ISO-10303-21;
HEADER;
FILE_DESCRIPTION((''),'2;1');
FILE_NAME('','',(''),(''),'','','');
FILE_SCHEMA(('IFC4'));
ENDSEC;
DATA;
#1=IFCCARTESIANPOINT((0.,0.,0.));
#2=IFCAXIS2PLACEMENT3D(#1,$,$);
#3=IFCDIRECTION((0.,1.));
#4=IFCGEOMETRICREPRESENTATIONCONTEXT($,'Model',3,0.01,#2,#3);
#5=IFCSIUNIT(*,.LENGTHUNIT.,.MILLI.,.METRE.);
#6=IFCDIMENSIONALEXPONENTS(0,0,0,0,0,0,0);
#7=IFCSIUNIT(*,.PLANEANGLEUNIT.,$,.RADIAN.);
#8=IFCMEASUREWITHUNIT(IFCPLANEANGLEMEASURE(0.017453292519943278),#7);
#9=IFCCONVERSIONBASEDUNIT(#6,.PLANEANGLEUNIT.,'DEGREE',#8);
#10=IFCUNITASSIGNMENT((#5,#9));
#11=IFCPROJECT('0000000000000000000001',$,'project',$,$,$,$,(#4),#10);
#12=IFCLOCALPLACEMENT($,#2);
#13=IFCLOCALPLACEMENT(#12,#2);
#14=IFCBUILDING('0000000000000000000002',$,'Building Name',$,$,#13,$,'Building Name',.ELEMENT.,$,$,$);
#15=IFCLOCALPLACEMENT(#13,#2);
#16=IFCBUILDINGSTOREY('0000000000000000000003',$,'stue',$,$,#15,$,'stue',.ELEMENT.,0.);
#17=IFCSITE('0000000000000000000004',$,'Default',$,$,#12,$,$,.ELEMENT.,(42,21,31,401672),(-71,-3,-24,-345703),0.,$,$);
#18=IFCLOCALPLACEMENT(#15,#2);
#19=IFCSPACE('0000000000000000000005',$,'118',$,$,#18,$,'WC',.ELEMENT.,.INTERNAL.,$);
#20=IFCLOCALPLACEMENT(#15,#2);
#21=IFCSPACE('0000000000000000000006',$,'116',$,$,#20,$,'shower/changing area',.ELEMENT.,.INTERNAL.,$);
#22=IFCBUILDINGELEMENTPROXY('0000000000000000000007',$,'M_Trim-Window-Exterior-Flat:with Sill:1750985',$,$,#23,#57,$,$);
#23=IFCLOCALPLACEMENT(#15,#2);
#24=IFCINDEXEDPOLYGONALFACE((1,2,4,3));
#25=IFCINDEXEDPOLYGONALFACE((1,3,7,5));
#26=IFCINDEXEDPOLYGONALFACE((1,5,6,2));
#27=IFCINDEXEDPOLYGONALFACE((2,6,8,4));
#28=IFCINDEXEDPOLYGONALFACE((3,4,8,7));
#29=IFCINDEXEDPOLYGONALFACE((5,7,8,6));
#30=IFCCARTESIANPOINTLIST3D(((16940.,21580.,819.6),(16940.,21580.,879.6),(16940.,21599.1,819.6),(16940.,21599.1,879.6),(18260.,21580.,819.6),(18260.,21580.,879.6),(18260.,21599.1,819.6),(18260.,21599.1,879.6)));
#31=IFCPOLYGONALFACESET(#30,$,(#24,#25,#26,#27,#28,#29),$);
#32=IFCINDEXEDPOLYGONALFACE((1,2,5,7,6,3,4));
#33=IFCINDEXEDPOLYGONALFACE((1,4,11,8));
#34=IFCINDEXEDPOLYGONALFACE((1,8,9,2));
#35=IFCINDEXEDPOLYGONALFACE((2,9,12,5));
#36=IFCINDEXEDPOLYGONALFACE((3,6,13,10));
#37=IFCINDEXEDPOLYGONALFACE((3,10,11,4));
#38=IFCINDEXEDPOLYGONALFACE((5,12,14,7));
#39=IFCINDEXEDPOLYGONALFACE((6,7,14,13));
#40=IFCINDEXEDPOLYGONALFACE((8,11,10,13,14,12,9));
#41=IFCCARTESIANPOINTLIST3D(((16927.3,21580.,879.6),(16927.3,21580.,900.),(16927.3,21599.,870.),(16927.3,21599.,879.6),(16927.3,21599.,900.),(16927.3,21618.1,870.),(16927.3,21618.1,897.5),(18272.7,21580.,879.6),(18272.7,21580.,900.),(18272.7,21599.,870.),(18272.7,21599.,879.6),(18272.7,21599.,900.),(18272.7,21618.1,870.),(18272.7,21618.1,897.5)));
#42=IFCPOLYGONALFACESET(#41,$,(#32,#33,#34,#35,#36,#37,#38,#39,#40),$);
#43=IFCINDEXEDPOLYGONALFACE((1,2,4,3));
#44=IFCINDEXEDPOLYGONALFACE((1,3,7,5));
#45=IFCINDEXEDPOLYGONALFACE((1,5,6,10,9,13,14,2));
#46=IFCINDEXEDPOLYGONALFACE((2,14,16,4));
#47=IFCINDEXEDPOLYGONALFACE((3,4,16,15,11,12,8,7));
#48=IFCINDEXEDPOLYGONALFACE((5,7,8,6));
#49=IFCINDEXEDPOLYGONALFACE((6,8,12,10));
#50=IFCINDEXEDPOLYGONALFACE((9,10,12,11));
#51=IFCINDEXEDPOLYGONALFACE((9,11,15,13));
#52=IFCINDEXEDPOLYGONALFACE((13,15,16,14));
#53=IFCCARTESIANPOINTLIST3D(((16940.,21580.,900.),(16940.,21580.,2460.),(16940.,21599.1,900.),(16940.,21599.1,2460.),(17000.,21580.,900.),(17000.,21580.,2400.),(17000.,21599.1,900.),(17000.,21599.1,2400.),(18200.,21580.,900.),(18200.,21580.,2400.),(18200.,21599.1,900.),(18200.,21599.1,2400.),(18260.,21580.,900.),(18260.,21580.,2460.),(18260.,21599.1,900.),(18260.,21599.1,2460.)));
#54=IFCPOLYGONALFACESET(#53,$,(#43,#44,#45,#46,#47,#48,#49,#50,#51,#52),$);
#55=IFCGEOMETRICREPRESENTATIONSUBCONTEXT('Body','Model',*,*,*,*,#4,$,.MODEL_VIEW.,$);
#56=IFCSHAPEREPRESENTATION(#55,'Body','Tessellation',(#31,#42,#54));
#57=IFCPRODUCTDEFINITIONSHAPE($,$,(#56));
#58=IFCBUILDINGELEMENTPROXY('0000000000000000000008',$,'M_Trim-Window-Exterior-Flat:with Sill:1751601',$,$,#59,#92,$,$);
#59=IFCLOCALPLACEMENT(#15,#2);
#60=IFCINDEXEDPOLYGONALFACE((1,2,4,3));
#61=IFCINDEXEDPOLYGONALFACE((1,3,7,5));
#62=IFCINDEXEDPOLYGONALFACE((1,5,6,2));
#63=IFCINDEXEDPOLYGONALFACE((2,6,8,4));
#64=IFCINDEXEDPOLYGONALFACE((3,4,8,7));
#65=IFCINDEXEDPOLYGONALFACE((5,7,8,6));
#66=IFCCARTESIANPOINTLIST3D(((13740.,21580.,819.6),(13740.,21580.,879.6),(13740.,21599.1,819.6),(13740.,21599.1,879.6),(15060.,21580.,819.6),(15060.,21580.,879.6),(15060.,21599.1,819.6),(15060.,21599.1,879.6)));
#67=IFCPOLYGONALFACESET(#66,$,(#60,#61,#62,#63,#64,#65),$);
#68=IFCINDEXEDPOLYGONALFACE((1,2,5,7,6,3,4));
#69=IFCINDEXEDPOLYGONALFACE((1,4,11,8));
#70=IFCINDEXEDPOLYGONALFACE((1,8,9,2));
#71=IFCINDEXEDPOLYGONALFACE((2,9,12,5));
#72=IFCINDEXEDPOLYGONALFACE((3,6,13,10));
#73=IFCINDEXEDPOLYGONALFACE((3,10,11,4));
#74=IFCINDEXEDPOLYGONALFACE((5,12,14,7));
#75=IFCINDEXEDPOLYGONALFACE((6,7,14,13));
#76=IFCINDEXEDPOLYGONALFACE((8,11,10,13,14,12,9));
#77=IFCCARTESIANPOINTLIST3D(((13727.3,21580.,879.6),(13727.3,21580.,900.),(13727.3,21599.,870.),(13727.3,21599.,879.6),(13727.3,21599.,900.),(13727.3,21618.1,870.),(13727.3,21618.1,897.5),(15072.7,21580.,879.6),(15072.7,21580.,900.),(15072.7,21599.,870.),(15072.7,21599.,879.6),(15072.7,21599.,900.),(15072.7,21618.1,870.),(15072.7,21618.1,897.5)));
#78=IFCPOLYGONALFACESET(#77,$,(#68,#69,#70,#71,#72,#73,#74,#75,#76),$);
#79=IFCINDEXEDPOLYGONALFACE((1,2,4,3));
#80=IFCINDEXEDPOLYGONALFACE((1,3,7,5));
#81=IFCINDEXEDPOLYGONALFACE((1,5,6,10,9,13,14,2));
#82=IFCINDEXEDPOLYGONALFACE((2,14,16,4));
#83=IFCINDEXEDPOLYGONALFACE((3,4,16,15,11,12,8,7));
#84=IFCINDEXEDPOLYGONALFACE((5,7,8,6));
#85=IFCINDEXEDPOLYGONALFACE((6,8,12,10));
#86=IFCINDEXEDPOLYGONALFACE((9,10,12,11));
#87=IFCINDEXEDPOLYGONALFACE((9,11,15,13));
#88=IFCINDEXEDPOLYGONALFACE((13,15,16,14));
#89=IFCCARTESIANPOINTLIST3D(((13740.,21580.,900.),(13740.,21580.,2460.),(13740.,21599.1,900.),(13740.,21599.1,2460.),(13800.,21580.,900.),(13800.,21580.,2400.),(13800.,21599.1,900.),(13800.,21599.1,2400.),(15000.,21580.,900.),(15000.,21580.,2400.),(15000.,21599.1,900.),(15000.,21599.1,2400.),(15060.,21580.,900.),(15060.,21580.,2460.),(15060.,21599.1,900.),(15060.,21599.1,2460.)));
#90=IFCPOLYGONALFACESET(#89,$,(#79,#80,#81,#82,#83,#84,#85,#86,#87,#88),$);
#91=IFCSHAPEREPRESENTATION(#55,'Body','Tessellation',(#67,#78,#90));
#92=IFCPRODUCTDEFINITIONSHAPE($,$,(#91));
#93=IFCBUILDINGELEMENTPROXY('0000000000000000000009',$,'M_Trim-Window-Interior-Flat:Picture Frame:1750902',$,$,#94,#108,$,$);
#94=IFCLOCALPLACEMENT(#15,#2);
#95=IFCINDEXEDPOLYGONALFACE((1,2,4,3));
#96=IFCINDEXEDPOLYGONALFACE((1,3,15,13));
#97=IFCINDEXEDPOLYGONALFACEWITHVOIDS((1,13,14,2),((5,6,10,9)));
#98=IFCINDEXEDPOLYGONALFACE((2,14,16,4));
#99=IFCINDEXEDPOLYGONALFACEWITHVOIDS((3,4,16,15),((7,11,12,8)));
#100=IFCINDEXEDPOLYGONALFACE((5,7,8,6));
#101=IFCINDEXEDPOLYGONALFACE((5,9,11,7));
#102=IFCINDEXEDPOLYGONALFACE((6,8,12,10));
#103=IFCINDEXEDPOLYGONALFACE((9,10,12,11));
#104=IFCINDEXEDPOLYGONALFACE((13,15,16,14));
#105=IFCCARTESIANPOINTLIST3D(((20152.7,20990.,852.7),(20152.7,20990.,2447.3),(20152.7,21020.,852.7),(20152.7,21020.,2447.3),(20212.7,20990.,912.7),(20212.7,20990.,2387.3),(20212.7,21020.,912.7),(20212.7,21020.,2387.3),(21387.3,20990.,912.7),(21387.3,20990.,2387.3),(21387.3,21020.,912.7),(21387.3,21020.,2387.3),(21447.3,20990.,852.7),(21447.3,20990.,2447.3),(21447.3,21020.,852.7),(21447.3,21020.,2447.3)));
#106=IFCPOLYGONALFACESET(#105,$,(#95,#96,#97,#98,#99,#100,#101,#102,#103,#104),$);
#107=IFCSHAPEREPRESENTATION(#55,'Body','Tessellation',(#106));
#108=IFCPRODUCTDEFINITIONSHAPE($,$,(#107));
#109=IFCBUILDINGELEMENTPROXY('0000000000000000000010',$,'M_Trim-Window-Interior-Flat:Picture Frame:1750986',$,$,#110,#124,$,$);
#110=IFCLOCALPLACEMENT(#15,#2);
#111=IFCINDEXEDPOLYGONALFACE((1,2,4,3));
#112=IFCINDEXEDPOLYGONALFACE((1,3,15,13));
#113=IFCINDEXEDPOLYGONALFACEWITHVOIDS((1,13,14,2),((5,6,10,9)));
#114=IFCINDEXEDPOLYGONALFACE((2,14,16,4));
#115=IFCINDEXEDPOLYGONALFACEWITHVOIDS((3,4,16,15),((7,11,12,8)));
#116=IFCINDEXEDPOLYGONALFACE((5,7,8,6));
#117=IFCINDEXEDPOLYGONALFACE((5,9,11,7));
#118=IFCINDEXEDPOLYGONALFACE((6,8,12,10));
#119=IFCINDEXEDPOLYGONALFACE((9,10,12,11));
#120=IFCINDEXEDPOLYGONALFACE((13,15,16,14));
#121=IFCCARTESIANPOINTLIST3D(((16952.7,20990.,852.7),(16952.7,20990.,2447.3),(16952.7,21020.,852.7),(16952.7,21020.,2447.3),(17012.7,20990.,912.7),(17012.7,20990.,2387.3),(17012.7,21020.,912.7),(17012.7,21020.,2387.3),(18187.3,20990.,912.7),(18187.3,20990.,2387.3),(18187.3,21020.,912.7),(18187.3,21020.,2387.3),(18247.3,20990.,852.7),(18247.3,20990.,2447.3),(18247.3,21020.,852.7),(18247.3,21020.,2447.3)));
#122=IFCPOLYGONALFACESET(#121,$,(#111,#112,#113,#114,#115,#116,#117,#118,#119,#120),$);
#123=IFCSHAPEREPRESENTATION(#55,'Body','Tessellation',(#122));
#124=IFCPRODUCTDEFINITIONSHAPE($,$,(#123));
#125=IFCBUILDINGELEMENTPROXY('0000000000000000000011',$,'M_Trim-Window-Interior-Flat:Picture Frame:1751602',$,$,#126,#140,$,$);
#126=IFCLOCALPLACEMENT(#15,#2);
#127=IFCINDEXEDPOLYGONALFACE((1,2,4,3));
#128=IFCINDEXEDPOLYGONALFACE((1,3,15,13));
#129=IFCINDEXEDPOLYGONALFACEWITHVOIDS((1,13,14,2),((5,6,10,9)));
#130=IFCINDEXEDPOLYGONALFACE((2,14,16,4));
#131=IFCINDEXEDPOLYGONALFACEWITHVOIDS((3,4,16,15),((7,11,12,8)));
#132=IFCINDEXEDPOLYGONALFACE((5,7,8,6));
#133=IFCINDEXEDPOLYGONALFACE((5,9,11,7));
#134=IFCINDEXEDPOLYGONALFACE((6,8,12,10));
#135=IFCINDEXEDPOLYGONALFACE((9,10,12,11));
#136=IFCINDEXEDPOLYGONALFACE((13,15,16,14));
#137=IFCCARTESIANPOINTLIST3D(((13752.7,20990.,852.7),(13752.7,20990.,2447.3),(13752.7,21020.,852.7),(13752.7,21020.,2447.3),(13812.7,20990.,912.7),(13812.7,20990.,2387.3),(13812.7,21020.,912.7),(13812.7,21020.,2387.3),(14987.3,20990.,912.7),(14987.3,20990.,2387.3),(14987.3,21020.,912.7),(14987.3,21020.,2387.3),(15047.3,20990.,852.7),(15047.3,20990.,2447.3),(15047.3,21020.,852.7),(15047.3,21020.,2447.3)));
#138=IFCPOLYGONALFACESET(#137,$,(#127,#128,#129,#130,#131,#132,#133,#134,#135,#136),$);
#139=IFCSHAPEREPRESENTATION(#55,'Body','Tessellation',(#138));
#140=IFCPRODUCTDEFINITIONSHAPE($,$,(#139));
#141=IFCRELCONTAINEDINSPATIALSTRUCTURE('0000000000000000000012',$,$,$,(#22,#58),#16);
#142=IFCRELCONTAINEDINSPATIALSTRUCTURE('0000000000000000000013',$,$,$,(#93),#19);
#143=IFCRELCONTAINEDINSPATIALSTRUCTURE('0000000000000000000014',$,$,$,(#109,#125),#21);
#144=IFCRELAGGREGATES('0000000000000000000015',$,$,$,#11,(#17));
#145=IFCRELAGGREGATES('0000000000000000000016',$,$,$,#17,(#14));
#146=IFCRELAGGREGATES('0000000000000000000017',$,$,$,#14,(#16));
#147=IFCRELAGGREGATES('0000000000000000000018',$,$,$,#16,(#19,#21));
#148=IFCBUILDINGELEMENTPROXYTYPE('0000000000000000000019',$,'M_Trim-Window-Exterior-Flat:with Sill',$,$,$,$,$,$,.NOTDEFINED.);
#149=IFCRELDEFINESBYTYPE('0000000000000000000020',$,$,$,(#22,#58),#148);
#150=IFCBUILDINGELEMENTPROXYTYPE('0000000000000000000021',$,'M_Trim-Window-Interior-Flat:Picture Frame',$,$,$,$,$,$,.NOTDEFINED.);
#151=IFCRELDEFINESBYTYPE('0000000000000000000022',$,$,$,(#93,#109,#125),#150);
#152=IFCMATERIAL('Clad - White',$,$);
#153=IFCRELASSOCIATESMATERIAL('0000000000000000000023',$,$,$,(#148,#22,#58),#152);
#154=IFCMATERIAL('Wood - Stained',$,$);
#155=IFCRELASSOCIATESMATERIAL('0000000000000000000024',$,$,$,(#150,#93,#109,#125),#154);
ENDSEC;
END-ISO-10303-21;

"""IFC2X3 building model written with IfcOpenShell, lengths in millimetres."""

from ifc_helpers import new_model, entity, si_unit, converted_unit, direction, frame, frame_2d, origin, place, context, subcontext, project, spatial, polyline, rectangle, outline, extrude, source, transform, mapped, material, type_object, type_shapes, element, save


model = new_model("IFC2X3")

# Units and contexts
model_context = context("Model", 3, precision=0.01, world=origin(), true_north=direction((0.0, 1.0)))
body_context = subcontext(model_context, "Body", "Model", "MODEL_VIEW")
ifc_project = project(units=[si_unit("LENGTHUNIT", "METRE", prefix="MILLI"), converted_unit("PLANEANGLEUNIT", "DEGREE", entity("IfcPlaneAngleMeasure", 0.017453292519943278), si_unit("PLANEANGLEUNIT", "RADIAN"), dimensions=[0, 0, 0, 0, 0, 0, 0])], contexts=[model_context])

# Site, building, storey
site_placement = place(None, origin())
site = spatial("IfcSite", under=ifc_project, at=site_placement, Name="Default", CompositionType="ELEMENT", RefLatitude=(42, 21, 31, 401672), RefLongitude=(-71, -3, -24, -345703), RefElevation=0.0)
building_placement = place(site_placement, origin())
building = spatial("IfcBuilding", under=site, at=building_placement, Name="Building Name", LongName="Building Name", CompositionType="ELEMENT")
storey_placement = place(building_placement, origin())
storey = spatial("IfcBuildingStorey", under=building, at=storey_placement, Name="stue", LongName="stue", CompositionType="ELEMENT", Elevation=0.0)

# Building element proxies
ifc_material_1 = material(Name="Clad - White")
ifc_material_2 = material(Name="Wood - Stained")
building_element_proxy_type_1 = type_object("IfcBuildingElementProxyType", Name="M_Trim-Window-Exterior-Flat:with Sill", PredefinedType="NOTDEFINED", material=ifc_material_1)
shared_shape_1 = source(origin(), body_context, "Body", "SweptSolid", [
    extrude(rectangle(XDim=1320.0, YDim=60.0, at=frame_2d((0.0, 0.0), x_axis=(1.0, 0.0))), frame((0.0, -1550.4, 0.0), z_axis=(0.0, 0.0, 1.0), x_axis=(-1.0, 0.0, 0.0)), (0.0, 0.0, 1.0), 19.0),
    extrude(outline(polyline([(-19.0, -15.2), (0.0, -15.2), (0.0, -5.7), (19.0, -5.7), (19.0, 14.8), (0.0, 14.8), (-19.0, 12.3), (-19.0, -15.2)])), frame((-672.7, -1514.8, 19.0), z_axis=(1.0, 0.0, 0.0), x_axis=(0.0, 0.0, -1.0)), (0.0, 0.0, 1.0), 1345.4),
    extrude(outline(polyline([(-795.0, -660.0), (765.0, -660.0), (765.0, -600.0), (-735.0, -600.0), (-735.0, 600.0), (765.0, 600.0), (765.0, 660.0), (-795.0, 660.0), (-795.0, -660.0)])), frame((0.0, -735.0, 0.0), z_axis=(0.0, 0.0, 1.0), x_axis=(0.0, -1.0, 0.0)), (0.0, 0.0, 1.0), 19.0),
])
type_shapes(building_element_proxy_type_1, [shared_shape_1])
for number, where, z_axis, x_axis, name in (
    (1, (17600.0, 21580.0, 2400.0), (0.0, 1.0, 0.0), (-1.0, 0.0, 0.0), "M_Trim-Window-Exterior-Flat:with Sill:1750985"),
    (2, (14400.0, 21580.0, 2400.0), (0.0, 1.0, 0.0), (-1.0, 0.0, 0.0), "M_Trim-Window-Exterior-Flat:with Sill:1751601"),
):
    element("IfcBuildingElementProxy", number, at=place(storey_placement, frame(where, z_axis=z_axis, x_axis=x_axis)), inside=storey, type_object=building_element_proxy_type_1, material=ifc_material_1, Name=name, context=body_context, shape_type="MappedRepresentation", body=[
        mapped(shared_shape_1, transform((0.0, 0.0, 0.0), scale=1.0)),
    ])

# Shared definitions
space_1_placement = place(storey_placement, origin())
space_1 = spatial("IfcSpace", under=storey, at=space_1_placement, Name="118", LongName="WC", CompositionType="ELEMENT", InteriorOrExteriorSpace="INTERNAL")

# Building element proxy
building_element_proxy_type_2 = type_object("IfcBuildingElementProxyType", Name="M_Trim-Window-Interior-Flat:Picture Frame", PredefinedType="NOTDEFINED", material=ifc_material_2)
shared_shape_2 = source(origin(), body_context, "Body", "SweptSolid", [
    extrude(outline(polyline([(-647.3, -797.3), (647.3, -797.3), (647.3, 797.3), (-647.3, 797.3), (-647.3, -797.3)]), holes=[polyline([(-587.3, -737.3), (-587.3, 737.3), (587.3, 737.3), (587.3, -737.3), (-587.3, -737.3)])]), frame((0.0, -750.0, 0.0), z_axis=(0.0, 0.0, 1.0), x_axis=(-1.0, 0.0, 0.0)), (0.0, 0.0, 1.0), 30.0),
])
type_shapes(building_element_proxy_type_2, [shared_shape_2])
proxy_placement = place(space_1_placement, frame((20800.0, 21020.0, 2400.0), z_axis=(0.0, -1.0, 0.0), x_axis=(1.0, 0.0, 0.0)))
element("IfcBuildingElementProxy", 3, at=proxy_placement, inside=space_1, type_object=building_element_proxy_type_2, material=ifc_material_2, Name="M_Trim-Window-Interior-Flat:Picture Frame:1750902", context=body_context, shape_type="MappedRepresentation", body=[
    mapped(shared_shape_2, transform((0.0, 0.0, 0.0), scale=1.0)),
])

# Shared definitions
space_2_placement = place(storey_placement, origin())
space_2 = spatial("IfcSpace", under=storey, at=space_2_placement, Name="116", LongName="shower/changing area", CompositionType="ELEMENT", InteriorOrExteriorSpace="INTERNAL")

# Building element proxies
for number, where, z_axis, x_axis, name in (
    (4, (17600.0, 21020.0, 2400.0), (0.0, -1.0, 0.0), (1.0, 0.0, 0.0), "M_Trim-Window-Interior-Flat:Picture Frame:1750986"),
    (5, (14400.0, 21020.0, 2400.0), (0.0, -1.0, 0.0), (1.0, 0.0, 0.0), "M_Trim-Window-Interior-Flat:Picture Frame:1751602"),
):
    element("IfcBuildingElementProxy", number, at=place(space_2_placement, frame(where, z_axis=z_axis, x_axis=x_axis)), inside=space_2, type_object=building_element_proxy_type_2, material=ifc_material_2, Name=name, context=body_context, shape_type="MappedRepresentation", body=[
        mapped(shared_shape_2, transform((0.0, 0.0, 0.0), scale=1.0)),
    ])

save(model, "model.ifc")
